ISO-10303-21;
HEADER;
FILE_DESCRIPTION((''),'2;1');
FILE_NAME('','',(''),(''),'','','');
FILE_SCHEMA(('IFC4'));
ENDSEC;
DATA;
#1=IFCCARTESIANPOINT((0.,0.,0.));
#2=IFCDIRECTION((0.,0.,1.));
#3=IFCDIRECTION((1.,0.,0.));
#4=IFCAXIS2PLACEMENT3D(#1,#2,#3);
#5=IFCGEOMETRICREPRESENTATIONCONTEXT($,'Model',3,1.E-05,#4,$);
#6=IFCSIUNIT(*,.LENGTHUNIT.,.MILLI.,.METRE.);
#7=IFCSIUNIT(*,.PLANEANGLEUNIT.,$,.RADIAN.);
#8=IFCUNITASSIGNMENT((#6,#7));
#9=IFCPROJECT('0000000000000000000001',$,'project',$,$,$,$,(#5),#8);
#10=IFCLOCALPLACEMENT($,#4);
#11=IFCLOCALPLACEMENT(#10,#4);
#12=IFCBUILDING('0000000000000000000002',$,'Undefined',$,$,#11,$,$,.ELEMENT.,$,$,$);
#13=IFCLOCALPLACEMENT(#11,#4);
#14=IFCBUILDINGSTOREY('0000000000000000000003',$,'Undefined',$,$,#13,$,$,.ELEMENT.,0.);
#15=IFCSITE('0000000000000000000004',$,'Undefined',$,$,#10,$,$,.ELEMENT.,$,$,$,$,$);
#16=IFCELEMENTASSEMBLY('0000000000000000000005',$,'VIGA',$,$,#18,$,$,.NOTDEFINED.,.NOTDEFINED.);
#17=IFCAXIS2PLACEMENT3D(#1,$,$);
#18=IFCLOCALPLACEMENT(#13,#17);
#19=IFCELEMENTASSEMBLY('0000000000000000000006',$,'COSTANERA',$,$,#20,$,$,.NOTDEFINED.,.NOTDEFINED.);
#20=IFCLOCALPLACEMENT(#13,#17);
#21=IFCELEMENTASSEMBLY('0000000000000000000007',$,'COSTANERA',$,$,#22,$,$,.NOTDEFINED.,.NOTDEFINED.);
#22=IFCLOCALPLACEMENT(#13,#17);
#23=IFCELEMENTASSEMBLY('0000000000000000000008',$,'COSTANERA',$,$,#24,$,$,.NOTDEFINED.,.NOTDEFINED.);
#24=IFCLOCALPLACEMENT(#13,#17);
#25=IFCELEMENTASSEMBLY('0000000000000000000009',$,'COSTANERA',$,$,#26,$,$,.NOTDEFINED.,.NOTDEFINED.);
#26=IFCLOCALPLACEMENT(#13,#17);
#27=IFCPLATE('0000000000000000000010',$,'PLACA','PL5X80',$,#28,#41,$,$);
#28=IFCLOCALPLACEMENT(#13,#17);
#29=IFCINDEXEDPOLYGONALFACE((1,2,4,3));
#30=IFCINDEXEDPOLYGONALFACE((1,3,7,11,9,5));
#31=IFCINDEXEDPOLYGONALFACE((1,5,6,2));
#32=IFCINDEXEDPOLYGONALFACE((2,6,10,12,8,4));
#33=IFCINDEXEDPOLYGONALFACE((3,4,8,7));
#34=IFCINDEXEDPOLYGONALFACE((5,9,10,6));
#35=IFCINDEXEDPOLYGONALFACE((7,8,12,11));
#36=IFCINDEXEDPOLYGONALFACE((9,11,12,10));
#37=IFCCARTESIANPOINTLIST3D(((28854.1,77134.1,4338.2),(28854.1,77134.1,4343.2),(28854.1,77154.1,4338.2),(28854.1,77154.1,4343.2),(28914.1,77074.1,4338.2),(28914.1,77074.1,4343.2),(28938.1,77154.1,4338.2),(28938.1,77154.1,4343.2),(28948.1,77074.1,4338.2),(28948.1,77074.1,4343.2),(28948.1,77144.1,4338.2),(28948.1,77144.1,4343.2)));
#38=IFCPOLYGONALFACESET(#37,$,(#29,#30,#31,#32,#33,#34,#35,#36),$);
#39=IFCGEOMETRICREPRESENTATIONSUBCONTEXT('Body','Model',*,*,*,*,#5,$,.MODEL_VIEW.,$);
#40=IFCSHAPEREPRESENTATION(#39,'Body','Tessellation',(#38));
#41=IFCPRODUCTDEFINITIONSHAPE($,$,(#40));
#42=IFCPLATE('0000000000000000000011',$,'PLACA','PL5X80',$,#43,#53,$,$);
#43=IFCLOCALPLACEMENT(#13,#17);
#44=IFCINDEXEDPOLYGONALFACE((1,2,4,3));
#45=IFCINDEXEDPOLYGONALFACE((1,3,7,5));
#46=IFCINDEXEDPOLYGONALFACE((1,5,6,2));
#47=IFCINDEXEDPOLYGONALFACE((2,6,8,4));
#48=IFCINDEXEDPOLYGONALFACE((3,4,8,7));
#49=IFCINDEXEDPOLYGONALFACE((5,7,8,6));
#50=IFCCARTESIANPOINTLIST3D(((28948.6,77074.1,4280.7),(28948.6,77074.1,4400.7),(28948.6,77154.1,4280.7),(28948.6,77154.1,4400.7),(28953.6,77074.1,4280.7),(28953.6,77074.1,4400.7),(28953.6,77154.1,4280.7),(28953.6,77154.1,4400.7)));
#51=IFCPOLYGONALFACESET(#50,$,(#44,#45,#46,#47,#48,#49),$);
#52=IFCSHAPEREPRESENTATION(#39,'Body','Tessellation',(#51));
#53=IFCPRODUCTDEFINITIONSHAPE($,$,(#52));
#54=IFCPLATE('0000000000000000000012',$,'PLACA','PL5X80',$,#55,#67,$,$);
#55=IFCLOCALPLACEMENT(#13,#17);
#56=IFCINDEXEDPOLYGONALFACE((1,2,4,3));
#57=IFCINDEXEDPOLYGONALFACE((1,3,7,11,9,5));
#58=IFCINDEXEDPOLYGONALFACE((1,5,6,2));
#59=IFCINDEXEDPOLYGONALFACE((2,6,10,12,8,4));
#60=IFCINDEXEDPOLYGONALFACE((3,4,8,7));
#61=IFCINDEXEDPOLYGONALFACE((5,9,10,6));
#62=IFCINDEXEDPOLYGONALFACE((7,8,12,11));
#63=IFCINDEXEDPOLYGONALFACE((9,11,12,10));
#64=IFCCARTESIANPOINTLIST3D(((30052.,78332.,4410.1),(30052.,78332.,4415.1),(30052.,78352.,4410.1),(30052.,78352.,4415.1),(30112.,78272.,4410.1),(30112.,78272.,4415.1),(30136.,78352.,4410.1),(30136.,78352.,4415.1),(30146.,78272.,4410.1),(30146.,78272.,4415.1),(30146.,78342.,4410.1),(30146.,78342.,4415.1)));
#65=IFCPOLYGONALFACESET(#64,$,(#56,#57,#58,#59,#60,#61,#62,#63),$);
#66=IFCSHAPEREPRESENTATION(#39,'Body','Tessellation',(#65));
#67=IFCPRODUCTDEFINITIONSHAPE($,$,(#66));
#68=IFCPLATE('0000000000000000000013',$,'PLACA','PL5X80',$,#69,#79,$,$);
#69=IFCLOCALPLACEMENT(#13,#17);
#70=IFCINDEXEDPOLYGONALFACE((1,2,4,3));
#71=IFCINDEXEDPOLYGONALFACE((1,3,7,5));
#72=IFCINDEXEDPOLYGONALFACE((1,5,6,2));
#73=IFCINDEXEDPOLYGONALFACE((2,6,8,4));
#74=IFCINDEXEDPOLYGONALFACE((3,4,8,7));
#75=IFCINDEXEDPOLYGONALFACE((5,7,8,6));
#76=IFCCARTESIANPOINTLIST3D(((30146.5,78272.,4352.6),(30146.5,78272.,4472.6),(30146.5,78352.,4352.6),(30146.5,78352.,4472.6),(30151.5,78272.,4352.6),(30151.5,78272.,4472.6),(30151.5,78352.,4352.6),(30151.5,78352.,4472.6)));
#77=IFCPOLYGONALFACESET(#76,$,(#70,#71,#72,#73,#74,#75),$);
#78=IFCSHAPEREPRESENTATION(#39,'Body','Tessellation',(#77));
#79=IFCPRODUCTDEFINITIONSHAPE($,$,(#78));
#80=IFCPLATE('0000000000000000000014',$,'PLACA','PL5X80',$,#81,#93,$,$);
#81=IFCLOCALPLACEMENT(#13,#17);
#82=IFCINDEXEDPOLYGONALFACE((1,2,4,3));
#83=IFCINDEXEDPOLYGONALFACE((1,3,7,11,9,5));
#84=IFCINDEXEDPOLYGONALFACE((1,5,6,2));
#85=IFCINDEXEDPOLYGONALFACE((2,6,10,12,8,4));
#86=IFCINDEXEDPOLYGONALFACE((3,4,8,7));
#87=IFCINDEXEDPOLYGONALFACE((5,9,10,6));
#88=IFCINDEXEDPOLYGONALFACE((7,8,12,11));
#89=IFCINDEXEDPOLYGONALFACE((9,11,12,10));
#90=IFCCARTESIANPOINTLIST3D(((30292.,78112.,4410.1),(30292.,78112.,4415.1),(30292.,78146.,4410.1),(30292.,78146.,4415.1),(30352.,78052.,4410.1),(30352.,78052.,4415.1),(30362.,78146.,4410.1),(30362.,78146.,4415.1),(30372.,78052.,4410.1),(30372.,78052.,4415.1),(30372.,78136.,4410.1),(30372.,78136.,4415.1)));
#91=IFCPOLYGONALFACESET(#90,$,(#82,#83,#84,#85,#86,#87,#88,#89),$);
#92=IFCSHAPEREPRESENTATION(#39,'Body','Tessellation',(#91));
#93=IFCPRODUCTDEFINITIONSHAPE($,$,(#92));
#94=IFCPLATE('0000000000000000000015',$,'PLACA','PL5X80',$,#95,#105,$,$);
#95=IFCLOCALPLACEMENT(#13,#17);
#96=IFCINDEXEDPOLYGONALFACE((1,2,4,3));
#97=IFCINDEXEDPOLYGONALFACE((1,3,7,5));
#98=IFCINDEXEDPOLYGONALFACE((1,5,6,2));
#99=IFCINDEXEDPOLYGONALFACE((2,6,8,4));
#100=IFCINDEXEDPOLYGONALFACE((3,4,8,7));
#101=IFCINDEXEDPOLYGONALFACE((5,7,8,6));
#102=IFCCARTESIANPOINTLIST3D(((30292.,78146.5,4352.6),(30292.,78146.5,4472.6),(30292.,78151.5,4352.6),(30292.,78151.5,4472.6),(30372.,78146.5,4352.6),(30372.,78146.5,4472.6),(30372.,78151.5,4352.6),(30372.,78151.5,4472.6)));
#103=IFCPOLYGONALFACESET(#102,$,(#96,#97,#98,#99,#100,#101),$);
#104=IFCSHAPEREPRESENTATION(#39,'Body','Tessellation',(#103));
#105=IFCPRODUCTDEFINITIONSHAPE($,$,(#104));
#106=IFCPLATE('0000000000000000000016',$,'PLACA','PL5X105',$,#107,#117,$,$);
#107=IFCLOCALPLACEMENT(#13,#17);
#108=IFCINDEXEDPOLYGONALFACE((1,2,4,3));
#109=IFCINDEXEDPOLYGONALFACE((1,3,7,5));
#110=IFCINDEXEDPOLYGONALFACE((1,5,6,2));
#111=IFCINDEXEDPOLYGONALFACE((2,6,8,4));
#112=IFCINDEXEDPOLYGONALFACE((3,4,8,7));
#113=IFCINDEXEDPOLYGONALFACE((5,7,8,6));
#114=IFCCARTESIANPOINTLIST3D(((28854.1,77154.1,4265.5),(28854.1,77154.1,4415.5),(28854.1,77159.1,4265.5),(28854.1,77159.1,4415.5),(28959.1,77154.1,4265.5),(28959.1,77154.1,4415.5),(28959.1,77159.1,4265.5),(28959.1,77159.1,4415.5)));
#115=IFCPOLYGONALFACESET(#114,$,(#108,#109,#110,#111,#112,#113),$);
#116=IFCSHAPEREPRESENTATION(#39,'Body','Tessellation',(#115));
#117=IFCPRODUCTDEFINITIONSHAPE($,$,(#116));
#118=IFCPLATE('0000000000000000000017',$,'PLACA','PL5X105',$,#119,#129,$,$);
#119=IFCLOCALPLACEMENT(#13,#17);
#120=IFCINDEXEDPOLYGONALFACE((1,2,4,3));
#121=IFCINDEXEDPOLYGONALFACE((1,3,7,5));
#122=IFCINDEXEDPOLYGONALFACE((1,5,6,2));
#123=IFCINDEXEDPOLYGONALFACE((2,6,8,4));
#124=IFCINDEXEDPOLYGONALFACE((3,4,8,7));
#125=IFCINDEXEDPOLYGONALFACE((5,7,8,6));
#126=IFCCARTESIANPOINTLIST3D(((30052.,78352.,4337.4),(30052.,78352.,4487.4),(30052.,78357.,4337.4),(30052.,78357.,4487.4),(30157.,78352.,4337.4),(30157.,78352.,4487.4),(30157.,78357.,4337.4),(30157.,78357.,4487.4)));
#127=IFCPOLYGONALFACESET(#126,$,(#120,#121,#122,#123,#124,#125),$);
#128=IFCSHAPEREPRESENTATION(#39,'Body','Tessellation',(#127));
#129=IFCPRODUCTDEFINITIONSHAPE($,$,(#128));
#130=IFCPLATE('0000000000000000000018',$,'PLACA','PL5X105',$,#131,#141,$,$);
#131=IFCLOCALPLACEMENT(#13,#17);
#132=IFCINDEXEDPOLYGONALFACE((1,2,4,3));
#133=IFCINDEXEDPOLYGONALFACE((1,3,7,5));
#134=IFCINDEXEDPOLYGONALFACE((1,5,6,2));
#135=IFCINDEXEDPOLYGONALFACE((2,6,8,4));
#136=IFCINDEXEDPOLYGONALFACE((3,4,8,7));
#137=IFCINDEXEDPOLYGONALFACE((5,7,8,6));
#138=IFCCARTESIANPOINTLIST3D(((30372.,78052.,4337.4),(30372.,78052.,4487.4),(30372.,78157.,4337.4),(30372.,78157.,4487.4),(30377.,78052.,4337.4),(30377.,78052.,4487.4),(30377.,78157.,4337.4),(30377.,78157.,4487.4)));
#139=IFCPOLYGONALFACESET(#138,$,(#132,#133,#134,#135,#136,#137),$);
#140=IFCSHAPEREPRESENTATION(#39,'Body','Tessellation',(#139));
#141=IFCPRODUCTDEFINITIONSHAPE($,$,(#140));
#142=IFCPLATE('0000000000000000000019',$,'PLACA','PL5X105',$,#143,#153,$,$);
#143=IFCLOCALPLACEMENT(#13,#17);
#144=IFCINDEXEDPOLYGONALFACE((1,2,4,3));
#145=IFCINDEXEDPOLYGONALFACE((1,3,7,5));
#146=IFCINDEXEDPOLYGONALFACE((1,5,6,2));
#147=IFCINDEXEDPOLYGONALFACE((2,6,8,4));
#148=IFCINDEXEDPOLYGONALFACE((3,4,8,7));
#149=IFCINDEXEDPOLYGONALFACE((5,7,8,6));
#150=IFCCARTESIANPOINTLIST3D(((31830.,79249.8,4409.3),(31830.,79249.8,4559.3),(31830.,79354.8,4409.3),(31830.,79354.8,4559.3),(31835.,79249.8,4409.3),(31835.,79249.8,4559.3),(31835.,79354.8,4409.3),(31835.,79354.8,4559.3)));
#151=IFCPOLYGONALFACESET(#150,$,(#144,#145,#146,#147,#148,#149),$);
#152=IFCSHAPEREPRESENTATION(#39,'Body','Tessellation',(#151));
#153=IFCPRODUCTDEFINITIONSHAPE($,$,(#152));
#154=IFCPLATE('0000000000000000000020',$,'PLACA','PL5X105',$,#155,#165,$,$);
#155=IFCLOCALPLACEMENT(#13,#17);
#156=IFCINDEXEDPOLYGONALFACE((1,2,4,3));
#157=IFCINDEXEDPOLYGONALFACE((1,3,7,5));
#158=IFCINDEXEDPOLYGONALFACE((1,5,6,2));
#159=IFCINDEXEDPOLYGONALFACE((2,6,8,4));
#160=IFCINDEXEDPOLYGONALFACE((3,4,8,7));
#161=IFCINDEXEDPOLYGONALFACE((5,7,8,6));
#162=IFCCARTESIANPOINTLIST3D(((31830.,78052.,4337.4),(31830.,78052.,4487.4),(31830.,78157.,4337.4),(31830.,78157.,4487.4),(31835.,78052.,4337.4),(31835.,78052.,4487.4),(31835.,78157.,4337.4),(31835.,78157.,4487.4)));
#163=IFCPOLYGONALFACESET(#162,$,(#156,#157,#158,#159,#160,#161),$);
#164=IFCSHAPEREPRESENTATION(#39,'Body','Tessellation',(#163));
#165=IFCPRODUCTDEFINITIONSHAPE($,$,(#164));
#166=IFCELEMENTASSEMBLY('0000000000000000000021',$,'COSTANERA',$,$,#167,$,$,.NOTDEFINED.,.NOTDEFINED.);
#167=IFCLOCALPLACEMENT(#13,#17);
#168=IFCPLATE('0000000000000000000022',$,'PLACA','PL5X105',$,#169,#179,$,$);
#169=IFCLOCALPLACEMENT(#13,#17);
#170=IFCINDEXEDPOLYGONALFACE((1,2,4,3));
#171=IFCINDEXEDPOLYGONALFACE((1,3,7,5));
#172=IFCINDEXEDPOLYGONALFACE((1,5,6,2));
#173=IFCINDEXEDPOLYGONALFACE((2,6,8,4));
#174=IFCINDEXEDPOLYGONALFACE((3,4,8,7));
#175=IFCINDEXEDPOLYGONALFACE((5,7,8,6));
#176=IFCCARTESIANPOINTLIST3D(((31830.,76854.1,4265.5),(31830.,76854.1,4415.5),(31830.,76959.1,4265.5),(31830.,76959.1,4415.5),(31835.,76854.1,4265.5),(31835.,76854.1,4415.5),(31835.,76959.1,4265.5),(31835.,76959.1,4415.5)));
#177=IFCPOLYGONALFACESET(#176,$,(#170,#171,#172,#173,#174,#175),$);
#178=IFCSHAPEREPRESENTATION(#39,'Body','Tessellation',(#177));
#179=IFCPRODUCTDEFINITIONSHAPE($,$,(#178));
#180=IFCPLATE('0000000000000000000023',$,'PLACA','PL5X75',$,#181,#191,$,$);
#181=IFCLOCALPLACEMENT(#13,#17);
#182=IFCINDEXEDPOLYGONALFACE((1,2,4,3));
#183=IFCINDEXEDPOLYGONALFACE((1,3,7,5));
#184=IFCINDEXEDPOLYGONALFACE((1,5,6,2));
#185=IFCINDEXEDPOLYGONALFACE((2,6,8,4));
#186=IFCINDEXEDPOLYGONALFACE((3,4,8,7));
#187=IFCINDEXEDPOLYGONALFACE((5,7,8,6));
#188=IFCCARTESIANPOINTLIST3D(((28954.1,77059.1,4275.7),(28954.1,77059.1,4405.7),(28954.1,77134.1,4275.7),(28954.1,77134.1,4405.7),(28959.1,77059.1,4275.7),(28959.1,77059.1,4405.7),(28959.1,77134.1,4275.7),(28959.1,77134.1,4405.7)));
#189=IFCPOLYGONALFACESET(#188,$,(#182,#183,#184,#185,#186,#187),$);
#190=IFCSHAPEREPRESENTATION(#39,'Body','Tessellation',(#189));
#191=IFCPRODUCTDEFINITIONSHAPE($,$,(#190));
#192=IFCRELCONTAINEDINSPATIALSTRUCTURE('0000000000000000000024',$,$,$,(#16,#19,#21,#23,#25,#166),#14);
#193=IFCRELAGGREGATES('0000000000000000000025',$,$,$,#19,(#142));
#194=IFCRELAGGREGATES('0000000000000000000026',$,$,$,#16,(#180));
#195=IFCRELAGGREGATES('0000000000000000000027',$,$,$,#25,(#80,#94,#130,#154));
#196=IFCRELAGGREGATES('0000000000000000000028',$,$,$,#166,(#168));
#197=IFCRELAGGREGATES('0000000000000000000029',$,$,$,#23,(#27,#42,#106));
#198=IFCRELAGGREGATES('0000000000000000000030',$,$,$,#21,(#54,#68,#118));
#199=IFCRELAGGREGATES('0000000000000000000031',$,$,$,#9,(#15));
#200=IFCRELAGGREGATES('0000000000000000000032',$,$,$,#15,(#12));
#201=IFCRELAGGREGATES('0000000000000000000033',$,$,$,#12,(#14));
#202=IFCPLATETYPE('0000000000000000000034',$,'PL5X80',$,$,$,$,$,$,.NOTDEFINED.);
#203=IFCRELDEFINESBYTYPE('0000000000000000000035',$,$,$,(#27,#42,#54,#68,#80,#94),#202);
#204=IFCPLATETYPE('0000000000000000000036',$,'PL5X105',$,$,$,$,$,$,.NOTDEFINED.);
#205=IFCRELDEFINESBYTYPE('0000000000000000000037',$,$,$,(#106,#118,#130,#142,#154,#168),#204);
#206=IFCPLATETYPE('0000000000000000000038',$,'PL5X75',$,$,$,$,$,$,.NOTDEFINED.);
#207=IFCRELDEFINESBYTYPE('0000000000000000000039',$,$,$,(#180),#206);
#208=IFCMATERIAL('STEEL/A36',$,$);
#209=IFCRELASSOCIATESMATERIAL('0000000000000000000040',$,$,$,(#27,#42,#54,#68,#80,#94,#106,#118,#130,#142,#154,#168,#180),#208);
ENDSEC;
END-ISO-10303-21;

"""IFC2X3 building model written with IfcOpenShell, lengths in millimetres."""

from ifc_helpers import new_model, si_unit, frame, origin_with_axes, place, context, subcontext, project, spatial, polyline, outline, extrude, material, type_object, element, aggregate, save


model = new_model("IFC2X3")

# Units and contexts
model_context = context("Model", 3, precision=1e-05, world=origin_with_axes())
body_context = subcontext(model_context, "Body", "Model", "MODEL_VIEW")
ifc_project = project(units=[si_unit("LENGTHUNIT", "METRE", prefix="MILLI"), si_unit("PLANEANGLEUNIT", "RADIAN")], contexts=[model_context])

# Site, building, storey
site_placement = place(None, origin_with_axes())
site = spatial("IfcSite", under=ifc_project, at=site_placement, Name="Undefined", CompositionType="ELEMENT")
building_placement = place(site_placement, origin_with_axes())
building = spatial("IfcBuilding", under=site, at=building_placement, Name="Undefined", CompositionType="ELEMENT")
storey_placement = place(building_placement, origin_with_axes())
storey = spatial("IfcBuildingStorey", under=building, at=storey_placement, Name="Undefined", CompositionType="ELEMENT", Elevation=0.0)

# Element assembly
assembly_1_placement = place(storey_placement, origin_with_axes())
assembly_1 = element("IfcElementAssembly", 1, at=assembly_1_placement, inside=storey, Name="VIGA", AssemblyPlace="NOTDEFINED", PredefinedType="NOTDEFINED")
ifc_material_1 = material(Name="STEEL/A36")

# Element assemblies
assembly_2_placement = place(storey_placement, origin_with_axes())
assembly_2 = element("IfcElementAssembly", 2, at=assembly_2_placement, inside=storey, Name="COSTANERA", AssemblyPlace="NOTDEFINED", PredefinedType="NOTDEFINED")
assembly_3_placement = place(storey_placement, origin_with_axes())
assembly_3 = element("IfcElementAssembly", 3, at=assembly_3_placement, inside=storey, Name="COSTANERA", AssemblyPlace="NOTDEFINED", PredefinedType="NOTDEFINED")
assembly_4_placement = place(storey_placement, origin_with_axes())
assembly_4 = element("IfcElementAssembly", 4, at=assembly_4_placement, inside=storey, Name="COSTANERA", AssemblyPlace="NOTDEFINED", PredefinedType="NOTDEFINED")

# Element assembly
assembly_5_placement = place(storey_placement, origin_with_axes())
assembly_5 = element("IfcElementAssembly", 5, at=assembly_5_placement, inside=storey, Name="COSTANERA", AssemblyPlace="NOTDEFINED", PredefinedType="NOTDEFINED")

# Plates
plate_type_1 = type_object("IfcPlateType", Name="PL5X80", PredefinedType="NOTDEFINED")
plate_1_placement = place(assembly_4_placement, frame((28948.1, 77074.1, 4340.7), z_axis=(0.0, 0.0, 1.0), x_axis=(0.0, 1.0, 0.0)))
plate_1 = element("IfcPlate", 6, at=plate_1_placement, type_object=plate_type_1, material=ifc_material_1, Name="PLACA", Description="PL5X80", context=body_context, shape_type="SweptSolid", body=[
    extrude(outline(polyline([(0.0, 0.0), (70.0, 0.0), (80.0, 10.0), (80.0, 94.0), (60.0, 94.0), (0.0, 34.0), (0.0, 0.0)])), frame((0.0, 0.0, -2.5), z_axis=(0.0, 0.0, 1.0), x_axis=(1.0, 0.0, 0.0)), (0.0, 0.0, 1.0), 5.0),
])
plate_2_placement = place(assembly_4_placement, frame((28951.1, 77074.1, 4400.7), z_axis=(-1.0, 0.0, 0.0), x_axis=(0.0, 1.0, 0.0)))
plate_2 = element("IfcPlate", 7, at=plate_2_placement, type_object=plate_type_1, material=ifc_material_1, Name="PLACA", Description="PL5X80", context=body_context, shape_type="SweptSolid", body=[
    extrude(outline(polyline([(0.0, 0.0), (80.0, 0.0), (80.0, 120.0), (0.0, 120.0), (0.0, 0.0)])), frame((0.0, 0.0, -2.5), z_axis=(0.0, 0.0, 1.0), x_axis=(1.0, 0.0, 0.0)), (0.0, 0.0, 1.0), 5.0),
])
plate_3_placement = place(assembly_3_placement, frame((30146.0, 78272.0, 4412.6), z_axis=(0.0, 0.0, 1.0), x_axis=(0.0, 1.0, 0.0)))
plate_3 = element("IfcPlate", 8, at=plate_3_placement, type_object=plate_type_1, material=ifc_material_1, Name="PLACA", Description="PL5X80", context=body_context, shape_type="SweptSolid", body=[
    extrude(outline(polyline([(0.0, 0.0), (70.0, 0.0), (80.0, 10.0), (80.0, 94.0), (60.0, 94.0), (0.0, 34.0), (0.0, 0.0)])), frame((0.0, 0.0, -2.5), z_axis=(0.0, 0.0, 1.0), x_axis=(1.0, 0.0, 0.0)), (0.0, 0.0, 1.0), 5.0),
])
plate_4_placement = place(assembly_3_placement, frame((30149.0, 78272.0, 4472.6), z_axis=(-1.0, 0.0, 0.0), x_axis=(0.0, 1.0, 0.0)))
plate_4 = element("IfcPlate", 9, at=plate_4_placement, type_object=plate_type_1, material=ifc_material_1, Name="PLACA", Description="PL5X80", context=body_context, shape_type="SweptSolid", body=[
    extrude(outline(polyline([(0.0, 0.0), (80.0, 0.0), (80.0, 120.0), (0.0, 120.0), (0.0, 0.0)])), frame((0.0, 0.0, -2.5), z_axis=(0.0, 0.0, 1.0), x_axis=(1.0, 0.0, 0.0)), (0.0, 0.0, 1.0), 5.0),
])
plate_5_placement = place(assembly_5_placement, frame((30292.0, 78146.0, 4412.6), z_axis=(0.0, 0.0, -1.0), x_axis=(1.0, 0.0, 0.0)))
plate_5 = element("IfcPlate", 10, at=plate_5_placement, type_object=plate_type_1, material=ifc_material_1, Name="PLACA", Description="PL5X80", context=body_context, shape_type="SweptSolid", body=[
    extrude(outline(polyline([(0.0, 0.0), (70.0, 0.0), (80.0, 10.0), (80.0, 94.0), (60.0, 94.0), (0.0, 34.0), (0.0, 0.0)])), frame((0.0, 0.0, -2.5), z_axis=(0.0, 0.0, 1.0), x_axis=(1.0, 0.0, 0.0)), (0.0, 0.0, 1.0), 5.0),
])
plate_6_placement = place(assembly_5_placement, frame((30292.0, 78149.0, 4472.6), z_axis=(0.0, 1.0, 0.0), x_axis=(1.0, 0.0, 0.0)))
plate_6 = element("IfcPlate", 11, at=plate_6_placement, type_object=plate_type_1, material=ifc_material_1, Name="PLACA", Description="PL5X80", context=body_context, shape_type="SweptSolid", body=[
    extrude(outline(polyline([(0.0, 0.0), (80.0, 0.0), (80.0, 120.0), (0.0, 120.0), (0.0, 0.0)])), frame((0.0, 0.0, -2.5), z_axis=(0.0, 0.0, 1.0), x_axis=(1.0, 0.0, 0.0)), (0.0, 0.0, 1.0), 5.0),
])
plate_type_2 = type_object("IfcPlateType", Name="PL5X105", PredefinedType="NOTDEFINED")
plate_7_placement = place(assembly_4_placement, frame((28959.1, 77156.6, 4265.5), z_axis=(0.0, 1.0, 0.0), x_axis=(-1.0, 0.0, 0.0)))
plate_7 = element("IfcPlate", 12, at=plate_7_placement, type_object=plate_type_2, material=ifc_material_1, Name="PLACA", Description="PL5X105", context=body_context, shape_type="SweptSolid", body=[
    extrude(outline(polyline([(0.0, 0.0), (105.0, 0.0), (105.0, 150.0), (0.0, 150.0), (0.0, 0.0)])), frame((0.0, 0.0, -2.5), z_axis=(0.0, 0.0, 1.0), x_axis=(1.0, 0.0, 0.0)), (0.0, 0.0, 1.0), 5.0),
])
plate_8_placement = place(assembly_3_placement, frame((30157.0, 78354.5, 4337.4), z_axis=(0.0, 1.0, 0.0), x_axis=(-1.0, 0.0, 0.0)))
plate_8 = element("IfcPlate", 13, at=plate_8_placement, type_object=plate_type_2, material=ifc_material_1, Name="PLACA", Description="PL5X105", context=body_context, shape_type="SweptSolid", body=[
    extrude(outline(polyline([(0.0, 0.0), (105.0, 0.0), (105.0, 150.0), (0.0, 150.0), (0.0, 0.0)])), frame((0.0, 0.0, -2.5), z_axis=(0.0, 0.0, 1.0), x_axis=(1.0, 0.0, 0.0)), (0.0, 0.0, 1.0), 5.0),
])
plate_9_placement = place(assembly_5_placement, frame((30374.5, 78052.0, 4337.4), z_axis=(1.0, 0.0, 0.0), x_axis=(0.0, 1.0, 0.0)))
plate_9 = element("IfcPlate", 14, at=plate_9_placement, type_object=plate_type_2, material=ifc_material_1, Name="PLACA", Description="PL5X105", context=body_context, shape_type="SweptSolid", body=[
    extrude(outline(polyline([(0.0, 0.0), (105.0, 0.0), (105.0, 150.0), (0.0, 150.0), (0.0, 0.0)])), frame((0.0, 0.0, -2.5), z_axis=(0.0, 0.0, 1.0), x_axis=(1.0, 0.0, 0.0)), (0.0, 0.0, 1.0), 5.0),
])
plate_10_placement = place(assembly_2_placement, frame((31832.5, 79354.8, 4409.3), z_axis=(-1.0, 0.0, 0.0), x_axis=(0.0, -1.0, 0.0)))
plate_10 = element("IfcPlate", 15, at=plate_10_placement, type_object=plate_type_2, material=ifc_material_1, Name="PLACA", Description="PL5X105", context=body_context, shape_type="SweptSolid", body=[
    extrude(outline(polyline([(0.0, 0.0), (105.0, 0.0), (105.0, 150.0), (0.0, 150.0), (0.0, 0.0)])), frame((0.0, 0.0, -2.5), z_axis=(0.0, 0.0, 1.0), x_axis=(1.0, 0.0, 0.0)), (0.0, 0.0, 1.0), 5.0),
])
aggregate(assembly_2, [plate_10])
plate_11_placement = place(assembly_5_placement, frame((31832.5, 78157.0, 4337.4), z_axis=(-1.0, 0.0, 0.0), x_axis=(0.0, -1.0, 0.0)))
plate_11 = element("IfcPlate", 16, at=plate_11_placement, type_object=plate_type_2, material=ifc_material_1, Name="PLACA", Description="PL5X105", context=body_context, shape_type="SweptSolid", body=[
    extrude(outline(polyline([(0.0, 0.0), (105.0, 0.0), (105.0, 150.0), (0.0, 150.0), (0.0, 0.0)])), frame((0.0, 0.0, -2.5), z_axis=(0.0, 0.0, 1.0), x_axis=(1.0, 0.0, 0.0)), (0.0, 0.0, 1.0), 5.0),
])

# Element assembly, plate
assembly_6_placement = place(storey_placement, origin_with_axes())
assembly_6 = element("IfcElementAssembly", 17, at=assembly_6_placement, inside=storey, Name="COSTANERA", AssemblyPlace="NOTDEFINED", PredefinedType="NOTDEFINED")
plate_12_placement = place(assembly_6_placement, frame((31832.5, 76959.1, 4265.5), z_axis=(-1.0, 0.0, 0.0), x_axis=(0.0, -1.0, 0.0)))
plate_12 = element("IfcPlate", 18, at=plate_12_placement, type_object=plate_type_2, material=ifc_material_1, Name="PLACA", Description="PL5X105", context=body_context, shape_type="SweptSolid", body=[
    extrude(outline(polyline([(0.0, 0.0), (105.0, 0.0), (105.0, 150.0), (0.0, 150.0), (0.0, 0.0)])), frame((0.0, 0.0, -2.5), z_axis=(0.0, 0.0, 1.0), x_axis=(1.0, 0.0, 0.0)), (0.0, 0.0, 1.0), 5.0),
])

# Plate
plate_type_3 = type_object("IfcPlateType", Name="PL5X75", PredefinedType="NOTDEFINED")
plate_13_placement = place(assembly_1_placement, frame((28956.6, 77059.1, 4405.7), z_axis=(-1.0, 0.000023, 0.0), x_axis=(0.000023, 1.0, 0.0)))
plate_13 = element("IfcPlate", 19, at=plate_13_placement, type_object=plate_type_3, material=ifc_material_1, Name="PLACA", Description="PL5X75", context=body_context, shape_type="SweptSolid", body=[
    extrude(outline(polyline([(0.0, 0.0), (75.0, 0.0), (75.0, 130.0), (0.0, 130.0), (0.0, 0.0)])), frame((0.0, 0.0, -2.5), z_axis=(0.0, 0.0, 1.0), x_axis=(1.0, 0.0, 0.0)), (0.0, 0.0, 1.0), 5.0),
])
aggregate(assembly_1, [plate_13])

aggregate(assembly_5, [plate_5, plate_6, plate_9, plate_11])
aggregate(assembly_6, [plate_12])
aggregate(assembly_4, [plate_1, plate_2, plate_7])
aggregate(assembly_3, [plate_3, plate_4, plate_8])

save(model, "model.ifc")
